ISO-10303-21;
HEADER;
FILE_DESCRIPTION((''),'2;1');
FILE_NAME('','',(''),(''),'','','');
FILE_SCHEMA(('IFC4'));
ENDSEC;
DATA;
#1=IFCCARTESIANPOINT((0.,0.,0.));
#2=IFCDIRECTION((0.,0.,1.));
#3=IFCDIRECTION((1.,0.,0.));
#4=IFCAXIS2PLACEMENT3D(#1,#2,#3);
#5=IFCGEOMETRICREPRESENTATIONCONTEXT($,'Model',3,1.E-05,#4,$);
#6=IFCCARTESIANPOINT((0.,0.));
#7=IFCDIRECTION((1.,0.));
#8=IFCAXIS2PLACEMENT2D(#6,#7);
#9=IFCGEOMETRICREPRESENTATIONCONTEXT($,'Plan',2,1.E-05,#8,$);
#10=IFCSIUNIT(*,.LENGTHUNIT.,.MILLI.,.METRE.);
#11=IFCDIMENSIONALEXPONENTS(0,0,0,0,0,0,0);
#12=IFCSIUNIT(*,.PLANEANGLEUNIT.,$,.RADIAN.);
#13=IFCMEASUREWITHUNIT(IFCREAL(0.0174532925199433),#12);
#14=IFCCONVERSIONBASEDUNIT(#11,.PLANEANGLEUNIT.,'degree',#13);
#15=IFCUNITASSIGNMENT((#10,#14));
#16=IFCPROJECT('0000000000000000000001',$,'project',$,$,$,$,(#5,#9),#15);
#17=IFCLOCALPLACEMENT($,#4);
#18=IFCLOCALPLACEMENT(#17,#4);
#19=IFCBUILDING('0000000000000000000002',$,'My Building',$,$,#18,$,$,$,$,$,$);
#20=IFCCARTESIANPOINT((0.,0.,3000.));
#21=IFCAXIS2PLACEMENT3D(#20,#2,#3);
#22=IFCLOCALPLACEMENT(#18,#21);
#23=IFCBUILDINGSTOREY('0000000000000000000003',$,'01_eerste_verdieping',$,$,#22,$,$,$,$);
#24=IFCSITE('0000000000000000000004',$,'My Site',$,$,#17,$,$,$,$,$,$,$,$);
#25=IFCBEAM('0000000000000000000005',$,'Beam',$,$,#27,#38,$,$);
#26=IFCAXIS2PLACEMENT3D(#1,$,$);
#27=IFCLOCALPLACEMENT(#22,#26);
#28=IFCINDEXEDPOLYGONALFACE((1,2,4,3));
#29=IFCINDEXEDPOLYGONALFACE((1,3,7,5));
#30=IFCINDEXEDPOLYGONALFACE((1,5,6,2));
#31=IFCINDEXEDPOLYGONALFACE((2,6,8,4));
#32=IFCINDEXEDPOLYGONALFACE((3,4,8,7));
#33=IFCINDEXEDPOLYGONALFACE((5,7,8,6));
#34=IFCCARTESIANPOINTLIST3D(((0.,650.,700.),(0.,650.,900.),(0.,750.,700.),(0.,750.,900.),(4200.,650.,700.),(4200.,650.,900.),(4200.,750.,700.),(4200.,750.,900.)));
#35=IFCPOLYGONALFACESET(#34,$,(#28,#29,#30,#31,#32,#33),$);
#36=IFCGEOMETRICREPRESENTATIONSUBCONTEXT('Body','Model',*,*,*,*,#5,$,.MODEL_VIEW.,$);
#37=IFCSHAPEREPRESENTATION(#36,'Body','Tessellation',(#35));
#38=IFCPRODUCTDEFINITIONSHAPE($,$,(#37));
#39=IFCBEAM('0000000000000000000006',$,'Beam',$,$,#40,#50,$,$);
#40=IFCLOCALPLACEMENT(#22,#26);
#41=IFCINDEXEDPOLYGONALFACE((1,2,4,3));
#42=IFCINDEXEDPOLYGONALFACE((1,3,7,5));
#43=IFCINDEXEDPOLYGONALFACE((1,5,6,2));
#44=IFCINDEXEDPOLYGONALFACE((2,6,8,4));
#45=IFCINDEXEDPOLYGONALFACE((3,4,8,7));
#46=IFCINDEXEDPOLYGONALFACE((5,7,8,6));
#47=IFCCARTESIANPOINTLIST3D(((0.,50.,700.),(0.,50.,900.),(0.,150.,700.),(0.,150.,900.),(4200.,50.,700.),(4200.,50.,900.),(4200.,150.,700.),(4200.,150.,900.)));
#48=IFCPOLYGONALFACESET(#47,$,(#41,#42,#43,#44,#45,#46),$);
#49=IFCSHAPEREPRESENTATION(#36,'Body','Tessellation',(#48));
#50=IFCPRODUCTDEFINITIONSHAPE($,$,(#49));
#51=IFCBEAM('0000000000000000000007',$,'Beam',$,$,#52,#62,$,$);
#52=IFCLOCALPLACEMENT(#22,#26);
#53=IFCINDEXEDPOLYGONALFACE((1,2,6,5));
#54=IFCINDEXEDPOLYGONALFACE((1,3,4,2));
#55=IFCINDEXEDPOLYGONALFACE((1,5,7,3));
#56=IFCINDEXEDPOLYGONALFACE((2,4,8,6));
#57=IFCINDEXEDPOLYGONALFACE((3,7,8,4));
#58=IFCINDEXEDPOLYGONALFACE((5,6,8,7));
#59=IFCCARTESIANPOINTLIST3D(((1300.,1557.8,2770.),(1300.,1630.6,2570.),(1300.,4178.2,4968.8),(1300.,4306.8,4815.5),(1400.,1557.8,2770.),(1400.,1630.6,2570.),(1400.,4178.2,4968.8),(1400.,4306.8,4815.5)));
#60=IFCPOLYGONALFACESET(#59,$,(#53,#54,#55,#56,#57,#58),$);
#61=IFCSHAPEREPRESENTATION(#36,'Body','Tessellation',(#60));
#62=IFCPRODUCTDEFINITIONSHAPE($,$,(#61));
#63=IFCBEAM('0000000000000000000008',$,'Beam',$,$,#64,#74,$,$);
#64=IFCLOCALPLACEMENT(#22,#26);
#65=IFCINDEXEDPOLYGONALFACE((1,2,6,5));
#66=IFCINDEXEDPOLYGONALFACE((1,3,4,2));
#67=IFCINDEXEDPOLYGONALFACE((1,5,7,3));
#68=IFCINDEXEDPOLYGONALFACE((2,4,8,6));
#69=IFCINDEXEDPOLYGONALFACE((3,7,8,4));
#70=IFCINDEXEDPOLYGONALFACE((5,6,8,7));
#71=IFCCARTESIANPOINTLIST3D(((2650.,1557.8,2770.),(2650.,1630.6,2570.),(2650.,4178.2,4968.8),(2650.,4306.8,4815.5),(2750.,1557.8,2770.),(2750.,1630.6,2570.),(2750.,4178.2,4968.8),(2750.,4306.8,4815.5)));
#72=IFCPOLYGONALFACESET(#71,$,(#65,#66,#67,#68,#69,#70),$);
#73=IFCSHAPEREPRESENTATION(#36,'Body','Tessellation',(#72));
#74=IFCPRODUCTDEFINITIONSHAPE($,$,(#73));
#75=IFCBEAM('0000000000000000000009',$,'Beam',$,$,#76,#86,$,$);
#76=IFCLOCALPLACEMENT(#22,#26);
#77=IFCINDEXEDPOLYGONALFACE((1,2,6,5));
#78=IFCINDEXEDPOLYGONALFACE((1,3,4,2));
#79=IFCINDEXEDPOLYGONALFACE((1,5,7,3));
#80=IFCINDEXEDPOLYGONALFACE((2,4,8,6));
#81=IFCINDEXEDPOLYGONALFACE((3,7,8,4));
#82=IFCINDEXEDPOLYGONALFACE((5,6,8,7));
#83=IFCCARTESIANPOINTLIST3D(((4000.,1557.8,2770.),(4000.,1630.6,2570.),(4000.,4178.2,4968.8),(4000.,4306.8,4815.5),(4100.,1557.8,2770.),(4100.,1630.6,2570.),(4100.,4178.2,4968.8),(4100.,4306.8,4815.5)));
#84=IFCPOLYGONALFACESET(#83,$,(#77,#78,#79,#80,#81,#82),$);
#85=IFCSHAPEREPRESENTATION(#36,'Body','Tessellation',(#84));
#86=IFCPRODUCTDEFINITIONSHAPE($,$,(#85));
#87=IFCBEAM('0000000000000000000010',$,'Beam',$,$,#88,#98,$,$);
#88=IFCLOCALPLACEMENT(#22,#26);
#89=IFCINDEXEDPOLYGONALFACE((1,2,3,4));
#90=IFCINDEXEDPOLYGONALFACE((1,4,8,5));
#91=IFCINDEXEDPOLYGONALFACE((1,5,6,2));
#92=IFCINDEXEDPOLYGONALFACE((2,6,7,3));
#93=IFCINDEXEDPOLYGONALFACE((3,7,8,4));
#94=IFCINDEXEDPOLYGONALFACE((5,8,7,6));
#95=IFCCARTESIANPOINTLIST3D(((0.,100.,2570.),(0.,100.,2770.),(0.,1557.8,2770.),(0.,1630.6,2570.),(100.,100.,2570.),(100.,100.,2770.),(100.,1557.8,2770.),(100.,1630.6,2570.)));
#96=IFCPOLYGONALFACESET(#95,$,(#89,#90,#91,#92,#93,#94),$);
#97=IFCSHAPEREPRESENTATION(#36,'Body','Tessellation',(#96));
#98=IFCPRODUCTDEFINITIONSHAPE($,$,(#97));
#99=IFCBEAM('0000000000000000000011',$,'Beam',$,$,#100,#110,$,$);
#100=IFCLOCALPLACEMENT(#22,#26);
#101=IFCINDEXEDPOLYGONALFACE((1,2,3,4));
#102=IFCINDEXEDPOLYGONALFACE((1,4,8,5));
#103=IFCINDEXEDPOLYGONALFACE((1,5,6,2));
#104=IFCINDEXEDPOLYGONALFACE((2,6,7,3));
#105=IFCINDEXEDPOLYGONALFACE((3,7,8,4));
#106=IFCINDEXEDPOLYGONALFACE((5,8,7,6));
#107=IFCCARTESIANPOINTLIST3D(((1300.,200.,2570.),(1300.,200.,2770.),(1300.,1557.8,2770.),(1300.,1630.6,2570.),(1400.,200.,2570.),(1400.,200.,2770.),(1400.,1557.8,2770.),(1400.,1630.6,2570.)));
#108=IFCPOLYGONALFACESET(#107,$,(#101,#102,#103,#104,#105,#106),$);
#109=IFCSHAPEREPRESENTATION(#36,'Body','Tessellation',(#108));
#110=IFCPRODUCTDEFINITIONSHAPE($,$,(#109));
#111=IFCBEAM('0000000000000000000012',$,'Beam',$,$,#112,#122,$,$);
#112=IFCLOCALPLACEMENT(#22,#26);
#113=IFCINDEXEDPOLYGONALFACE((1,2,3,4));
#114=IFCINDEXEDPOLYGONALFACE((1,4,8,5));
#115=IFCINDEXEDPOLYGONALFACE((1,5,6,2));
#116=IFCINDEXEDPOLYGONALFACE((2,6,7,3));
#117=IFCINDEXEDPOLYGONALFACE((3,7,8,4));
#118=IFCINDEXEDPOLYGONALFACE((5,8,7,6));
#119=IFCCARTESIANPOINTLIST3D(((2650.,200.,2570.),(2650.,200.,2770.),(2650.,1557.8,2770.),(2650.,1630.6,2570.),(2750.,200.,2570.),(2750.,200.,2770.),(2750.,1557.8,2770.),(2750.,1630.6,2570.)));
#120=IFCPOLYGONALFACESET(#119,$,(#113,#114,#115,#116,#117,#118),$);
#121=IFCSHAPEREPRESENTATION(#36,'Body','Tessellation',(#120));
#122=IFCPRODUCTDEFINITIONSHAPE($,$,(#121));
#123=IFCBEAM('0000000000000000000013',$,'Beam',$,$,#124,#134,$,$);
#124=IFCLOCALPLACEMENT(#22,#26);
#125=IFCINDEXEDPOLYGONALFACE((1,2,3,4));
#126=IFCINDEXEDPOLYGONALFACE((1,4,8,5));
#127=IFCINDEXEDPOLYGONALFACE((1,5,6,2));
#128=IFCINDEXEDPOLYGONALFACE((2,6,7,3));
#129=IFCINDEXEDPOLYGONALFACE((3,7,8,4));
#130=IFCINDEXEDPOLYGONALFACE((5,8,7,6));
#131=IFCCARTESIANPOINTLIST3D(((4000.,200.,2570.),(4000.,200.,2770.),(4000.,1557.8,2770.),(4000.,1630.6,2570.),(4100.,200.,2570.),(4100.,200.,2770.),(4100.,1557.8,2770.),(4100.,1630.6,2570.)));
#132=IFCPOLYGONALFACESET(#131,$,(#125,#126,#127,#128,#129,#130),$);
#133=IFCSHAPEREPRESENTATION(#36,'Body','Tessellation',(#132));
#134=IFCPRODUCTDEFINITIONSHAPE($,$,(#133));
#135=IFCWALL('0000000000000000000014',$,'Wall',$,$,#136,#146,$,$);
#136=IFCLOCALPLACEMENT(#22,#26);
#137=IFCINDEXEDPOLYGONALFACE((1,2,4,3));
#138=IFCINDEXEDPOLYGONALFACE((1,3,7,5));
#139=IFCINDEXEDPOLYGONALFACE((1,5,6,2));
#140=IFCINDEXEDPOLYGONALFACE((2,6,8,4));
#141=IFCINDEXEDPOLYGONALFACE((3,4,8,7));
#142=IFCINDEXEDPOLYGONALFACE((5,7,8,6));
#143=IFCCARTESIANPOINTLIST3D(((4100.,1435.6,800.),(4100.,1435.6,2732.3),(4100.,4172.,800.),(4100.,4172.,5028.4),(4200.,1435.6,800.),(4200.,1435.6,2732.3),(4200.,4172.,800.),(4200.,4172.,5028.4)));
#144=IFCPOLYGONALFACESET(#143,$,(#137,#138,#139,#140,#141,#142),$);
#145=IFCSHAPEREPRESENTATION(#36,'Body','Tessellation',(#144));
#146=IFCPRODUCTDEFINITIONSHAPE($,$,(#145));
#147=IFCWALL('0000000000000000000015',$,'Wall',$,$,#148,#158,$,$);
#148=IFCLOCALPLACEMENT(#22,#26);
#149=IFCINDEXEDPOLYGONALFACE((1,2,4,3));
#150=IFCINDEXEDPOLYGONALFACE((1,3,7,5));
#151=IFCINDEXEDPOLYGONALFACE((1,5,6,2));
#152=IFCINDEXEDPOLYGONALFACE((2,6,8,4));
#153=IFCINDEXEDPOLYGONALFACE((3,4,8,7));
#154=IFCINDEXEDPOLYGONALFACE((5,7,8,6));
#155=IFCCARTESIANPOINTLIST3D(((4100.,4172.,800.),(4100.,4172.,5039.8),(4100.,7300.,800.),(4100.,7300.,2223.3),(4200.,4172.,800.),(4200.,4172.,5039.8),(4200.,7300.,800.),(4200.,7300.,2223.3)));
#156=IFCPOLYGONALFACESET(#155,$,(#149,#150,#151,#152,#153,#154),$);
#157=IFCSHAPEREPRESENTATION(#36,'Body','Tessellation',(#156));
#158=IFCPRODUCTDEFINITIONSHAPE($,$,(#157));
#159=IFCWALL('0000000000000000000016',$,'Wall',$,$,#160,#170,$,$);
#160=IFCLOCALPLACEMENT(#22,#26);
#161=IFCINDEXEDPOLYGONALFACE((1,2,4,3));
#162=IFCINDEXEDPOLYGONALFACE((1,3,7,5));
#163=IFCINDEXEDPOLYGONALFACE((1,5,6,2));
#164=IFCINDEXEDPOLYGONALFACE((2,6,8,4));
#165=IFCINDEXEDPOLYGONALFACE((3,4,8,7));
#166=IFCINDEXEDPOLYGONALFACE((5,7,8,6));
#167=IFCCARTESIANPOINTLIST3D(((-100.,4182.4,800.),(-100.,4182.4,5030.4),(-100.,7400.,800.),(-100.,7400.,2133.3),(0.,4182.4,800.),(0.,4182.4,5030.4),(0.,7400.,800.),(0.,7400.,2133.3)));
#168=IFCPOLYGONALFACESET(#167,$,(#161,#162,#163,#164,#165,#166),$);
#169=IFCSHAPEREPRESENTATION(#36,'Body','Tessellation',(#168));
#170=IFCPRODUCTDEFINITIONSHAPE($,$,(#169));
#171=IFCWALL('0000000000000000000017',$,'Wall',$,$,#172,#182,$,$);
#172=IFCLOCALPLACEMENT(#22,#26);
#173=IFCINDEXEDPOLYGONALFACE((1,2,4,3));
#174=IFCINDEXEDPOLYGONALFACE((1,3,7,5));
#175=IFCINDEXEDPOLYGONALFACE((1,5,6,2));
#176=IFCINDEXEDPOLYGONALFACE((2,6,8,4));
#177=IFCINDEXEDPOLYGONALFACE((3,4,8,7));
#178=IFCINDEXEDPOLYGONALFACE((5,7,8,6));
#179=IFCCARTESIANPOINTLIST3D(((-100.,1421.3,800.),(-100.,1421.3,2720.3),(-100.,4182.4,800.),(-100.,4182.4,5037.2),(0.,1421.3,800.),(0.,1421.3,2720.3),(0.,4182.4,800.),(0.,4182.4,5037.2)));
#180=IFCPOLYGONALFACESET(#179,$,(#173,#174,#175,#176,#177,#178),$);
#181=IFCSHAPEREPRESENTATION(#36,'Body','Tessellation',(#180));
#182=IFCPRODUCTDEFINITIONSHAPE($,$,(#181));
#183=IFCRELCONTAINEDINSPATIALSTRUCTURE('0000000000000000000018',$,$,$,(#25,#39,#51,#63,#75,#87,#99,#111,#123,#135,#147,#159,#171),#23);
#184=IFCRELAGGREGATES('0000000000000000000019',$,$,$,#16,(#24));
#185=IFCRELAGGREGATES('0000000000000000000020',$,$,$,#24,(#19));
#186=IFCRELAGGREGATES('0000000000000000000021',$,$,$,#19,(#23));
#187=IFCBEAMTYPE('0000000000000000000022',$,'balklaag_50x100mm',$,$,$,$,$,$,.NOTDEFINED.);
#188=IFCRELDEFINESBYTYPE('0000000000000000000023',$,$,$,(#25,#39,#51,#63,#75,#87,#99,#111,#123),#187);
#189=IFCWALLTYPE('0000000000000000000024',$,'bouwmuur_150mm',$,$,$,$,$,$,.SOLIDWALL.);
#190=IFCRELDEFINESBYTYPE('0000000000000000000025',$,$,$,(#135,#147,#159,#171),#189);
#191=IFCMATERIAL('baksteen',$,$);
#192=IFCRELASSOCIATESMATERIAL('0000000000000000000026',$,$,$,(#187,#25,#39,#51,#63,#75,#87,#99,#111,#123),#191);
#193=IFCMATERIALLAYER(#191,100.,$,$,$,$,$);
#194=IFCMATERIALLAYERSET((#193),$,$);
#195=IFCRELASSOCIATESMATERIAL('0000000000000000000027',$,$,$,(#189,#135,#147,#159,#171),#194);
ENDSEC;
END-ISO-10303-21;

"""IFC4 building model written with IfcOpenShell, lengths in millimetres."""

from ifc_helpers import new_model, entity, si_unit, converted_unit, frame, origin_with_axes, origin_2d_with_axis, place, context, subcontext, project, spatial, indexed_curve, rectangle, outline, extrude, clip, halfspace, material, layer, layer_set, layer_usage, material_profile, profile_set, profile_usage, type_object, element, save


model = new_model("IFC4")

# Units and contexts
model_context = context("Model", 3, precision=1e-05, world=origin_with_axes())
plan_context = context("Plan", 2, precision=1e-05, world=origin_2d_with_axis())
body_context = subcontext(model_context, "Body", "Model", "MODEL_VIEW")
ifc_project = project(units=[si_unit("LENGTHUNIT", "METRE", prefix="MILLI"), converted_unit("PLANEANGLEUNIT", "degree", entity("IfcReal", 0.0174532925199433), si_unit("PLANEANGLEUNIT", "RADIAN"), dimensions=[0, 0, 0, 0, 0, 0, 0])], contexts=[model_context, plan_context])

# Site, building, storey
site_placement = place(None, origin_with_axes())
site = spatial("IfcSite", under=ifc_project, at=site_placement, Name="My Site")
building_placement = place(site_placement, origin_with_axes())
building = spatial("IfcBuilding", under=site, at=building_placement, Name="My Building")
storey_placement = place(building_placement, frame((0.0, 0.0, 3000.0), z_axis=(0.0, 0.0, 1.0), x_axis=(1.0, 0.0, 0.0)))
storey = spatial("IfcBuildingStorey", under=building, at=storey_placement, Name="01_eerste_verdieping")

# Beams
ifc_material = material(Name="baksteen")
ifc_material_profile_1 = material_profile(ifc_material, rectangle(XDim=100.0, YDim=200.0))
ifc_profile_set_1 = profile_set([ifc_material_profile_1])
beam_type_1 = type_object("IfcBeamType", Name="balklaag_50x100mm", PredefinedType="NOTDEFINED", material=ifc_profile_set_1)
ifc_profile_usage_1 = profile_usage(ifc_profile_set_1, cardinal=5)
beam_1_placement = place(storey_placement, frame((4200.0, 700.0, 800.0), z_axis=(-1.0, 0.0, 0.0), x_axis=(0.0, -1.0, 0.0)))
element("IfcBeam", 1, at=beam_1_placement, inside=storey, type_object=beam_type_1, material=ifc_profile_usage_1, Name="Beam", context=body_context, shape_type="SweptSolid", body=[
    extrude(rectangle(XDim=100.0, YDim=200.0), origin_with_axes(), (0.0, 0.0, 1.0), 4200.0),
])
ifc_profile_usage_2 = profile_usage(ifc_profile_set_1, cardinal=5)
beam_2_placement = place(storey_placement, frame((4200.0, 100.0, 800.0), z_axis=(-1.0, 0.0, 0.0), x_axis=(0.0, -1.0, 0.0)))
element("IfcBeam", 2, at=beam_2_placement, inside=storey, type_object=beam_type_1, material=ifc_profile_usage_2, Name="Beam", context=body_context, shape_type="SweptSolid", body=[
    extrude(rectangle(XDim=100.0, YDim=200.0), origin_with_axes(), (0.0, 0.0, 1.0), 4200.0),
])
ifc_profile_usage_3 = profile_usage(ifc_profile_set_1, cardinal=5)
beam_3_placement = place(storey_placement, frame((1350.0, 4242.5, 4892.2), z_axis=(0.0, -0.766045, -0.642787), x_axis=(1.0, 0.0, 0.0)))
element("IfcBeam", 3, at=beam_3_placement, inside=storey, type_object=beam_type_1, material=ifc_profile_usage_3, Name="Beam", context=body_context, shape_type="Clipping", body=[
    clip(extrude(rectangle(XDim=100.0, YDim=200.0), origin_with_axes(), (0.0, 0.0, 1.0), 3812.6), halfspace(frame((-1350.0, -100.0, 3493.5), z_axis=(0.0, 0.342017, 0.939694), x_axis=(0.0, 0.939694, -0.342017)), False)),
])
ifc_profile_usage_4 = profile_usage(ifc_profile_set_1, cardinal=5)
beam_4_placement = place(storey_placement, frame((2700.0, 4242.5, 4892.2), z_axis=(0.0, -0.766045, -0.642787), x_axis=(1.0, 0.0, 0.0)))
element("IfcBeam", 4, at=beam_4_placement, inside=storey, type_object=beam_type_1, material=ifc_profile_usage_4, Name="Beam", context=body_context, shape_type="Clipping", body=[
    clip(extrude(rectangle(XDim=100.0, YDim=200.0), origin_with_axes(), (0.0, 0.0, 1.0), 3812.6), halfspace(frame((-2700.0, -100.0, 3493.5), z_axis=(0.0, 0.342016, 0.939694), x_axis=(0.0, 0.939694, -0.342016)), False)),
])
ifc_profile_usage_5 = profile_usage(ifc_profile_set_1, cardinal=5)
beam_5_placement = place(storey_placement, frame((4050.0, 4242.5, 4892.2), z_axis=(0.0, -0.766045, -0.642787), x_axis=(1.0, 0.0, 0.0)))
element("IfcBeam", 5, at=beam_5_placement, inside=storey, type_object=beam_type_1, material=ifc_profile_usage_5, Name="Beam", context=body_context, shape_type="Clipping", body=[
    clip(extrude(rectangle(XDim=100.0, YDim=200.0), origin_with_axes(), (0.0, 0.0, 1.0), 3812.6), halfspace(frame((-4050.0, -100.0, 3493.5), z_axis=(0.0, 0.342014, 0.939695), x_axis=(0.0, 0.939695, -0.342014)), False)),
])
ifc_profile_usage_6 = profile_usage(ifc_profile_set_1, cardinal=5)
beam_6_placement = place(storey_placement, frame((50.0, 1949.8, 2670.0), z_axis=(0.0, -1.0, 0.0), x_axis=(1.0, 0.0, 0.0)))
element("IfcBeam", 6, at=beam_6_placement, inside=storey, type_object=beam_type_1, material=ifc_profile_usage_6, Name="Beam", context=body_context, shape_type="Clipping", body=[
    clip(extrude(rectangle(XDim=100.0, YDim=200.0), origin_with_axes(), (0.0, 0.0, 1.0), 1849.8), halfspace(frame((-50.0, -100.0, 319.2), z_axis=(0.0, 0.342026, -0.939691), x_axis=(0.0, 0.939691, 0.342026)), False)),
])
ifc_profile_usage_7 = profile_usage(ifc_profile_set_1, cardinal=5)
beam_7_placement = place(storey_placement, frame((1350.0, 1949.8, 2670.0), z_axis=(0.0, -1.0, 0.0), x_axis=(1.0, 0.0, 0.0)))
element("IfcBeam", 7, at=beam_7_placement, inside=storey, type_object=beam_type_1, material=ifc_profile_usage_7, Name="Beam", context=body_context, shape_type="Clipping", body=[
    clip(extrude(rectangle(XDim=100.0, YDim=200.0), origin_with_axes(), (0.0, 0.0, 1.0), 1749.8), halfspace(frame((-1350.0, -100.0, 319.2), z_axis=(0.0, 0.342021, -0.939692), x_axis=(0.0, 0.939692, 0.342021)), False)),
])
ifc_profile_usage_8 = profile_usage(ifc_profile_set_1, cardinal=5)
beam_8_placement = place(storey_placement, frame((2700.0, 1949.8, 2670.0), z_axis=(0.0, -1.0, 0.0), x_axis=(1.0, 0.0, 0.0)))
element("IfcBeam", 8, at=beam_8_placement, inside=storey, type_object=beam_type_1, material=ifc_profile_usage_8, Name="Beam", context=body_context, shape_type="Clipping", body=[
    clip(extrude(rectangle(XDim=100.0, YDim=200.0), origin_with_axes(), (0.0, 0.0, 1.0), 1749.8), halfspace(frame((-2700.0, -100.0, 319.2), z_axis=(0.0, 0.342021, -0.939692), x_axis=(0.0, 0.939692, 0.342021)), False)),
])
ifc_profile_usage_9 = profile_usage(ifc_profile_set_1, cardinal=5)
beam_9_placement = place(storey_placement, frame((4050.0, 1949.8, 2670.0), z_axis=(0.0, -1.0, 0.0), x_axis=(1.0, 0.0, 0.0)))
element("IfcBeam", 9, at=beam_9_placement, inside=storey, type_object=beam_type_1, material=ifc_profile_usage_9, Name="Beam", context=body_context, shape_type="Clipping", body=[
    clip(extrude(rectangle(XDim=100.0, YDim=200.0), origin_with_axes(), (0.0, 0.0, 1.0), 1749.8), halfspace(frame((-4050.0, -100.0, 319.2), z_axis=(0.0, 0.342019, -0.939693), x_axis=(0.0, 0.939693, 0.342019)), False)),
])

# Walls
ifc_layer_1 = layer(ifc_material, 100.0)
ifc_layer_set_1 = layer_set([ifc_layer_1])
ifc_layer_usage_1 = layer_usage(ifc_layer_set_1, "AXIS2", "POSITIVE", 0.0)
wall_type = type_object("IfcWallType", Name="bouwmuur_150mm", PredefinedType="SOLIDWALL", material=ifc_layer_set_1)
wall_1_placement = place(storey_placement, frame((4200.0, 1435.6, 800.0), z_axis=(0.0, 0.0, 1.0), x_axis=(0.0, 1.0, 0.0)))
element("IfcWall", 10, at=wall_1_placement, inside=storey, type_object=wall_type, material=ifc_layer_usage_1, Name="Wall", context=body_context, shape_type="Clipping", body=[
    clip(extrude(outline(indexed_curve([(0.0, 0.0), (0.0, 100.0), (2736.4, 100.0), (2736.4, 0.0), (0.0, 0.0)], self_intersect=False)), origin_with_axes(), (0.0, 0.0, 1.0), 9233.0), halfspace(frame((4172.0, 0.0, 5433.0), z_axis=(-0.642788, 0.0, 0.766044), x_axis=(0.0, -1.0, 0.0)), False)),
])
ifc_layer_usage_2 = layer_usage(ifc_layer_set_1, "AXIS2", "POSITIVE", 0.0)
wall_2_placement = place(storey_placement, frame((4200.0, 4172.0, 800.0), z_axis=(0.0, 0.0, 1.0), x_axis=(0.0, 1.0, 0.0)))
element("IfcWall", 11, at=wall_2_placement, inside=storey, type_object=wall_type, material=ifc_layer_usage_2, Name="Wall", context=body_context, shape_type="Clipping", body=[
    clip(extrude(outline(indexed_curve([(0.0, 0.0), (0.0, 100.0), (3128.0, 100.0), (3128.0, 0.0), (0.0, 0.0)], self_intersect=False)), origin_with_axes(), (0.0, 0.0, 1.0), 8039.8), halfspace(frame((0.0, 0.0, 4239.8), z_axis=(0.669131, 0.0, 0.743145), x_axis=(-0.000001, 1.0, 0.0)), False)),
])
ifc_layer_usage_3 = layer_usage(ifc_layer_set_1, "AXIS2", "POSITIVE", 0.0)
wall_3_placement = place(storey_placement, frame((-100.0, 7400.0, 800.0), z_axis=(0.0, 0.0, 1.0), x_axis=(-0.000001, -1.0, 0.0)))
element("IfcWall", 12, at=wall_3_placement, inside=storey, type_object=wall_type, material=ifc_layer_usage_3, Name="Wall", context=body_context, shape_type="Clipping", body=[
    clip(extrude(outline(indexed_curve([(0.0, 0.0), (0.0, 100.0), (3217.6, 100.0), (3217.6, 0.0), (0.0, 0.0)], self_intersect=False)), origin_with_axes(), (0.0, 0.0, 1.0), 8030.4), halfspace(frame((3217.6, 0.0, 4230.4), z_axis=(-0.669131, -0.000001, 0.743145), x_axis=(0.000001, -1.0, 0.0)), False)),
])
ifc_layer_usage_4 = layer_usage(ifc_layer_set_1, "AXIS2", "POSITIVE", 0.0)
wall_4_placement = place(storey_placement, frame((-100.0, 4182.4, 800.0), z_axis=(0.0, 0.0, 1.0), x_axis=(0.0, -1.0, 0.0)))
element("IfcWall", 13, at=wall_4_placement, inside=storey, type_object=wall_type, material=ifc_layer_usage_4, Name="Wall", context=body_context, shape_type="Clipping", body=[
    clip(extrude(outline(indexed_curve([(0.0, 0.0), (0.0, 100.0), (2761.2, 100.0), (2761.2, 0.0), (0.0, 0.0)], self_intersect=False)), origin_with_axes(), (0.0, 0.0, 1.0), 8037.2), halfspace(frame((0.0, 0.0, 4237.2), z_axis=(0.642788, 0.0, 0.766044), x_axis=(0.0, 1.0, 0.0)), False)),
])

save(model, "model.ifc")
